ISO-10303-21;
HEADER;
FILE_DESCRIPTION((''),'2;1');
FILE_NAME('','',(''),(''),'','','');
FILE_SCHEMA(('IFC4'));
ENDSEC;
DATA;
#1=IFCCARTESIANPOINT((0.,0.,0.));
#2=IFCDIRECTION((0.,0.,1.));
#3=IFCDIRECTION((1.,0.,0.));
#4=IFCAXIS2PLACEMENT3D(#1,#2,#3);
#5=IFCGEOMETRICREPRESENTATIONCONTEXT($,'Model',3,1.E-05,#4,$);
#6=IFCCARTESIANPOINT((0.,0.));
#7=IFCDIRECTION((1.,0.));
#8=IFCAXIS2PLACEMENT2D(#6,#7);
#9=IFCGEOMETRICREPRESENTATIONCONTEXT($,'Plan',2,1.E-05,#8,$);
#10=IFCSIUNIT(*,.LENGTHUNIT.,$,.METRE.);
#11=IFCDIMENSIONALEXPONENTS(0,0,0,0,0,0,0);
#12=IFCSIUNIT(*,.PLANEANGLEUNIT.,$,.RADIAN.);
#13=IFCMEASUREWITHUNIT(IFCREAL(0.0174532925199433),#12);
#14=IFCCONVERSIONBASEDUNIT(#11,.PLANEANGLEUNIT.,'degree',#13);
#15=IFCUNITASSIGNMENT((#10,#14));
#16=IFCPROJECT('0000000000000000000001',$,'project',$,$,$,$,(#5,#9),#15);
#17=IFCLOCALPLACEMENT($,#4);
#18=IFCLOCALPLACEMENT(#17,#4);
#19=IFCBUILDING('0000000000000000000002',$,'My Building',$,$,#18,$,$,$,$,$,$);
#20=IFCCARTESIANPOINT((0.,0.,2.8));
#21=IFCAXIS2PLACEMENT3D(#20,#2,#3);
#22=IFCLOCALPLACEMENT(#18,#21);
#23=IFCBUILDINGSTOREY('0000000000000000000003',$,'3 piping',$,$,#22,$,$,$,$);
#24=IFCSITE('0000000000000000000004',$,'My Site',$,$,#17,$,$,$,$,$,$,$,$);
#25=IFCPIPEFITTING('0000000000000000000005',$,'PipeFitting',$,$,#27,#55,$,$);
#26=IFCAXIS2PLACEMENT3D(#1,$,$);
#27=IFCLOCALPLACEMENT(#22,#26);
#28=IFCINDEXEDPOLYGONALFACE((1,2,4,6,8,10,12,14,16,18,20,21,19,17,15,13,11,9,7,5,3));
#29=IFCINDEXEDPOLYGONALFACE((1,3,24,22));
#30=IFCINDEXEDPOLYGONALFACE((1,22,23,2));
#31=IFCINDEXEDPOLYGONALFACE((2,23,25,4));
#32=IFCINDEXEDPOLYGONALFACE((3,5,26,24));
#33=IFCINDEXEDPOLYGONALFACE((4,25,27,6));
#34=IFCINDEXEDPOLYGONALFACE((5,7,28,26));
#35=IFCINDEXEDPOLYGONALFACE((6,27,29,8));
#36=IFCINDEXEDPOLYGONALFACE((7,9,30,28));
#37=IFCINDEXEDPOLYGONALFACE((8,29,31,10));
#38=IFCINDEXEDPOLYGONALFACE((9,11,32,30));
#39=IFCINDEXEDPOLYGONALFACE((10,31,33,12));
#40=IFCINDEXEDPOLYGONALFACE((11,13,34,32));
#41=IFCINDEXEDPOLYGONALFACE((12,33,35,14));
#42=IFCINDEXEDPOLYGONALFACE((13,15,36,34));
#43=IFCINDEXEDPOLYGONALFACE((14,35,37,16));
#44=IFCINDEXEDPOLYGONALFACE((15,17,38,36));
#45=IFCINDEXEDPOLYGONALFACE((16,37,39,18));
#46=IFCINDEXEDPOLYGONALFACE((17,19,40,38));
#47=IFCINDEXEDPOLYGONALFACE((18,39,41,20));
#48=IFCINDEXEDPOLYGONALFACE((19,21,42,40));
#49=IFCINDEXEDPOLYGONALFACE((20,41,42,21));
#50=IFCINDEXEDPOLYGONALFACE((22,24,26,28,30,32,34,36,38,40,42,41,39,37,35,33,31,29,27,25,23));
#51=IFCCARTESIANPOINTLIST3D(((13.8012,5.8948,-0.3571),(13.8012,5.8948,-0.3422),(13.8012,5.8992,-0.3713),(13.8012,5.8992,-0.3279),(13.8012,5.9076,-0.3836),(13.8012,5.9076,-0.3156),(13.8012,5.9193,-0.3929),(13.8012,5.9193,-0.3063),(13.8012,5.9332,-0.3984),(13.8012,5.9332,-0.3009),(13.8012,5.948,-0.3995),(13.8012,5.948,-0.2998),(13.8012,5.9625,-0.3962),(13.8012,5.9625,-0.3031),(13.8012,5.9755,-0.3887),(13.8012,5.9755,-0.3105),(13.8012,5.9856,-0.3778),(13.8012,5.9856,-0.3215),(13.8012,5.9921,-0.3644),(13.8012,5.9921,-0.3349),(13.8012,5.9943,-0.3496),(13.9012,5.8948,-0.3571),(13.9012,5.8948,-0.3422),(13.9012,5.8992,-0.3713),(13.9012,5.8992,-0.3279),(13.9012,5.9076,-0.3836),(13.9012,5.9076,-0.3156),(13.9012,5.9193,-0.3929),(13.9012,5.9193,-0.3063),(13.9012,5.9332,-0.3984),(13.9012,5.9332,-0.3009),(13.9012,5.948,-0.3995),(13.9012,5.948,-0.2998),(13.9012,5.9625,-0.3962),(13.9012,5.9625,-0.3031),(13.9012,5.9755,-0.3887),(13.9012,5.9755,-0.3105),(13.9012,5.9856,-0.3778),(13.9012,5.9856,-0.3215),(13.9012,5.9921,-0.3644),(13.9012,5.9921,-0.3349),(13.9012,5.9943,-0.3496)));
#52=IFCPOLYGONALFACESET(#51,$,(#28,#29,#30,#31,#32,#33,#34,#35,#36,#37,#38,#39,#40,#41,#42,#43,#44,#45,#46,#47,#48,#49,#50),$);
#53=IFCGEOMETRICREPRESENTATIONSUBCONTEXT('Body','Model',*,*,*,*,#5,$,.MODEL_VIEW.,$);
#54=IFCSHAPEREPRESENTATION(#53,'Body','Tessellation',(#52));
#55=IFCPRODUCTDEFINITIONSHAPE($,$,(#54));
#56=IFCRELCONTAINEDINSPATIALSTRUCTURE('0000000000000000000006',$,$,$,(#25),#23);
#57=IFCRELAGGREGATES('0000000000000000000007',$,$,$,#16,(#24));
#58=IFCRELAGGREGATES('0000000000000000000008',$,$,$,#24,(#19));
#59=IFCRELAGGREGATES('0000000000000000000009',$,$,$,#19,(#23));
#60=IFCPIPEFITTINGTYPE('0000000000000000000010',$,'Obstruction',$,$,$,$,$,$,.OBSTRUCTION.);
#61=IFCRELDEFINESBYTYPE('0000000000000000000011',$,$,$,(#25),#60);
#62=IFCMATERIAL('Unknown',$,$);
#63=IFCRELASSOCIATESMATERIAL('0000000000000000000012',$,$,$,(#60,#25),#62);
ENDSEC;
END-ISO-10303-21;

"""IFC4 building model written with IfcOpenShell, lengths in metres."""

from ifc_helpers import new_model, entity, si_unit, converted_unit, frame, origin_with_axes, origin_2d_with_axis, place, context, subcontext, project, spatial, circle, extrude, material, material_profile, profile_set, profile_usage, type_object, element, save


model = new_model("IFC4")

# Units and contexts
model_context = context("Model", 3, precision=1e-05, world=origin_with_axes())
plan_context = context("Plan", 2, precision=1e-05, world=origin_2d_with_axis())
body_context = subcontext(model_context, "Body", "Model", "MODEL_VIEW")
ifc_project = project(units=[si_unit("LENGTHUNIT", "METRE"), converted_unit("PLANEANGLEUNIT", "degree", entity("IfcReal", 0.0174532925199433), si_unit("PLANEANGLEUNIT", "RADIAN"), dimensions=[0, 0, 0, 0, 0, 0, 0])], contexts=[model_context, plan_context])

# Site, building, storey
site_placement = place(None, origin_with_axes())
site = spatial("IfcSite", under=ifc_project, at=site_placement, Name="My Site")
building_placement = place(site_placement, origin_with_axes())
building = spatial("IfcBuilding", under=site, at=building_placement, Name="My Building")
storey_placement = place(building_placement, frame((0.0, 0.0, 2.8), z_axis=(0.0, 0.0, 1.0), x_axis=(1.0, 0.0, 0.0)))
storey = spatial("IfcBuildingStorey", under=building, at=storey_placement, Name="3 piping")

# Shared definitions
ifc_material = material(Name="Unknown")

# Pipe fitting
ifc_material_profile_1 = material_profile(ifc_material, circle(Radius=0.05))
ifc_profile_set_1 = profile_set([ifc_material_profile_1])
ifc_profile_usage_1 = profile_usage(ifc_profile_set_1, cardinal=5)
pipe_fitting_type_1 = type_object("IfcPipeFittingType", Name="Obstruction", PredefinedType="OBSTRUCTION", material=ifc_profile_set_1)
pipe_fitting_placement = place(storey_placement, frame((13.8012, 5.9443, -0.3496), z_axis=(1.0, 0.0, 0.0), x_axis=(0.0, 1.0, 0.0)))
element("IfcPipeFitting", 1, at=pipe_fitting_placement, inside=storey, type_object=pipe_fitting_type_1, material=ifc_profile_usage_1, Name="PipeFitting", context=body_context, shape_type="SweptSolid", body=[
    extrude(circle(Radius=0.05), origin_with_axes(), (0.0, 0.0, 1.0), 0.1),
])

save(model, "model.ifc")
